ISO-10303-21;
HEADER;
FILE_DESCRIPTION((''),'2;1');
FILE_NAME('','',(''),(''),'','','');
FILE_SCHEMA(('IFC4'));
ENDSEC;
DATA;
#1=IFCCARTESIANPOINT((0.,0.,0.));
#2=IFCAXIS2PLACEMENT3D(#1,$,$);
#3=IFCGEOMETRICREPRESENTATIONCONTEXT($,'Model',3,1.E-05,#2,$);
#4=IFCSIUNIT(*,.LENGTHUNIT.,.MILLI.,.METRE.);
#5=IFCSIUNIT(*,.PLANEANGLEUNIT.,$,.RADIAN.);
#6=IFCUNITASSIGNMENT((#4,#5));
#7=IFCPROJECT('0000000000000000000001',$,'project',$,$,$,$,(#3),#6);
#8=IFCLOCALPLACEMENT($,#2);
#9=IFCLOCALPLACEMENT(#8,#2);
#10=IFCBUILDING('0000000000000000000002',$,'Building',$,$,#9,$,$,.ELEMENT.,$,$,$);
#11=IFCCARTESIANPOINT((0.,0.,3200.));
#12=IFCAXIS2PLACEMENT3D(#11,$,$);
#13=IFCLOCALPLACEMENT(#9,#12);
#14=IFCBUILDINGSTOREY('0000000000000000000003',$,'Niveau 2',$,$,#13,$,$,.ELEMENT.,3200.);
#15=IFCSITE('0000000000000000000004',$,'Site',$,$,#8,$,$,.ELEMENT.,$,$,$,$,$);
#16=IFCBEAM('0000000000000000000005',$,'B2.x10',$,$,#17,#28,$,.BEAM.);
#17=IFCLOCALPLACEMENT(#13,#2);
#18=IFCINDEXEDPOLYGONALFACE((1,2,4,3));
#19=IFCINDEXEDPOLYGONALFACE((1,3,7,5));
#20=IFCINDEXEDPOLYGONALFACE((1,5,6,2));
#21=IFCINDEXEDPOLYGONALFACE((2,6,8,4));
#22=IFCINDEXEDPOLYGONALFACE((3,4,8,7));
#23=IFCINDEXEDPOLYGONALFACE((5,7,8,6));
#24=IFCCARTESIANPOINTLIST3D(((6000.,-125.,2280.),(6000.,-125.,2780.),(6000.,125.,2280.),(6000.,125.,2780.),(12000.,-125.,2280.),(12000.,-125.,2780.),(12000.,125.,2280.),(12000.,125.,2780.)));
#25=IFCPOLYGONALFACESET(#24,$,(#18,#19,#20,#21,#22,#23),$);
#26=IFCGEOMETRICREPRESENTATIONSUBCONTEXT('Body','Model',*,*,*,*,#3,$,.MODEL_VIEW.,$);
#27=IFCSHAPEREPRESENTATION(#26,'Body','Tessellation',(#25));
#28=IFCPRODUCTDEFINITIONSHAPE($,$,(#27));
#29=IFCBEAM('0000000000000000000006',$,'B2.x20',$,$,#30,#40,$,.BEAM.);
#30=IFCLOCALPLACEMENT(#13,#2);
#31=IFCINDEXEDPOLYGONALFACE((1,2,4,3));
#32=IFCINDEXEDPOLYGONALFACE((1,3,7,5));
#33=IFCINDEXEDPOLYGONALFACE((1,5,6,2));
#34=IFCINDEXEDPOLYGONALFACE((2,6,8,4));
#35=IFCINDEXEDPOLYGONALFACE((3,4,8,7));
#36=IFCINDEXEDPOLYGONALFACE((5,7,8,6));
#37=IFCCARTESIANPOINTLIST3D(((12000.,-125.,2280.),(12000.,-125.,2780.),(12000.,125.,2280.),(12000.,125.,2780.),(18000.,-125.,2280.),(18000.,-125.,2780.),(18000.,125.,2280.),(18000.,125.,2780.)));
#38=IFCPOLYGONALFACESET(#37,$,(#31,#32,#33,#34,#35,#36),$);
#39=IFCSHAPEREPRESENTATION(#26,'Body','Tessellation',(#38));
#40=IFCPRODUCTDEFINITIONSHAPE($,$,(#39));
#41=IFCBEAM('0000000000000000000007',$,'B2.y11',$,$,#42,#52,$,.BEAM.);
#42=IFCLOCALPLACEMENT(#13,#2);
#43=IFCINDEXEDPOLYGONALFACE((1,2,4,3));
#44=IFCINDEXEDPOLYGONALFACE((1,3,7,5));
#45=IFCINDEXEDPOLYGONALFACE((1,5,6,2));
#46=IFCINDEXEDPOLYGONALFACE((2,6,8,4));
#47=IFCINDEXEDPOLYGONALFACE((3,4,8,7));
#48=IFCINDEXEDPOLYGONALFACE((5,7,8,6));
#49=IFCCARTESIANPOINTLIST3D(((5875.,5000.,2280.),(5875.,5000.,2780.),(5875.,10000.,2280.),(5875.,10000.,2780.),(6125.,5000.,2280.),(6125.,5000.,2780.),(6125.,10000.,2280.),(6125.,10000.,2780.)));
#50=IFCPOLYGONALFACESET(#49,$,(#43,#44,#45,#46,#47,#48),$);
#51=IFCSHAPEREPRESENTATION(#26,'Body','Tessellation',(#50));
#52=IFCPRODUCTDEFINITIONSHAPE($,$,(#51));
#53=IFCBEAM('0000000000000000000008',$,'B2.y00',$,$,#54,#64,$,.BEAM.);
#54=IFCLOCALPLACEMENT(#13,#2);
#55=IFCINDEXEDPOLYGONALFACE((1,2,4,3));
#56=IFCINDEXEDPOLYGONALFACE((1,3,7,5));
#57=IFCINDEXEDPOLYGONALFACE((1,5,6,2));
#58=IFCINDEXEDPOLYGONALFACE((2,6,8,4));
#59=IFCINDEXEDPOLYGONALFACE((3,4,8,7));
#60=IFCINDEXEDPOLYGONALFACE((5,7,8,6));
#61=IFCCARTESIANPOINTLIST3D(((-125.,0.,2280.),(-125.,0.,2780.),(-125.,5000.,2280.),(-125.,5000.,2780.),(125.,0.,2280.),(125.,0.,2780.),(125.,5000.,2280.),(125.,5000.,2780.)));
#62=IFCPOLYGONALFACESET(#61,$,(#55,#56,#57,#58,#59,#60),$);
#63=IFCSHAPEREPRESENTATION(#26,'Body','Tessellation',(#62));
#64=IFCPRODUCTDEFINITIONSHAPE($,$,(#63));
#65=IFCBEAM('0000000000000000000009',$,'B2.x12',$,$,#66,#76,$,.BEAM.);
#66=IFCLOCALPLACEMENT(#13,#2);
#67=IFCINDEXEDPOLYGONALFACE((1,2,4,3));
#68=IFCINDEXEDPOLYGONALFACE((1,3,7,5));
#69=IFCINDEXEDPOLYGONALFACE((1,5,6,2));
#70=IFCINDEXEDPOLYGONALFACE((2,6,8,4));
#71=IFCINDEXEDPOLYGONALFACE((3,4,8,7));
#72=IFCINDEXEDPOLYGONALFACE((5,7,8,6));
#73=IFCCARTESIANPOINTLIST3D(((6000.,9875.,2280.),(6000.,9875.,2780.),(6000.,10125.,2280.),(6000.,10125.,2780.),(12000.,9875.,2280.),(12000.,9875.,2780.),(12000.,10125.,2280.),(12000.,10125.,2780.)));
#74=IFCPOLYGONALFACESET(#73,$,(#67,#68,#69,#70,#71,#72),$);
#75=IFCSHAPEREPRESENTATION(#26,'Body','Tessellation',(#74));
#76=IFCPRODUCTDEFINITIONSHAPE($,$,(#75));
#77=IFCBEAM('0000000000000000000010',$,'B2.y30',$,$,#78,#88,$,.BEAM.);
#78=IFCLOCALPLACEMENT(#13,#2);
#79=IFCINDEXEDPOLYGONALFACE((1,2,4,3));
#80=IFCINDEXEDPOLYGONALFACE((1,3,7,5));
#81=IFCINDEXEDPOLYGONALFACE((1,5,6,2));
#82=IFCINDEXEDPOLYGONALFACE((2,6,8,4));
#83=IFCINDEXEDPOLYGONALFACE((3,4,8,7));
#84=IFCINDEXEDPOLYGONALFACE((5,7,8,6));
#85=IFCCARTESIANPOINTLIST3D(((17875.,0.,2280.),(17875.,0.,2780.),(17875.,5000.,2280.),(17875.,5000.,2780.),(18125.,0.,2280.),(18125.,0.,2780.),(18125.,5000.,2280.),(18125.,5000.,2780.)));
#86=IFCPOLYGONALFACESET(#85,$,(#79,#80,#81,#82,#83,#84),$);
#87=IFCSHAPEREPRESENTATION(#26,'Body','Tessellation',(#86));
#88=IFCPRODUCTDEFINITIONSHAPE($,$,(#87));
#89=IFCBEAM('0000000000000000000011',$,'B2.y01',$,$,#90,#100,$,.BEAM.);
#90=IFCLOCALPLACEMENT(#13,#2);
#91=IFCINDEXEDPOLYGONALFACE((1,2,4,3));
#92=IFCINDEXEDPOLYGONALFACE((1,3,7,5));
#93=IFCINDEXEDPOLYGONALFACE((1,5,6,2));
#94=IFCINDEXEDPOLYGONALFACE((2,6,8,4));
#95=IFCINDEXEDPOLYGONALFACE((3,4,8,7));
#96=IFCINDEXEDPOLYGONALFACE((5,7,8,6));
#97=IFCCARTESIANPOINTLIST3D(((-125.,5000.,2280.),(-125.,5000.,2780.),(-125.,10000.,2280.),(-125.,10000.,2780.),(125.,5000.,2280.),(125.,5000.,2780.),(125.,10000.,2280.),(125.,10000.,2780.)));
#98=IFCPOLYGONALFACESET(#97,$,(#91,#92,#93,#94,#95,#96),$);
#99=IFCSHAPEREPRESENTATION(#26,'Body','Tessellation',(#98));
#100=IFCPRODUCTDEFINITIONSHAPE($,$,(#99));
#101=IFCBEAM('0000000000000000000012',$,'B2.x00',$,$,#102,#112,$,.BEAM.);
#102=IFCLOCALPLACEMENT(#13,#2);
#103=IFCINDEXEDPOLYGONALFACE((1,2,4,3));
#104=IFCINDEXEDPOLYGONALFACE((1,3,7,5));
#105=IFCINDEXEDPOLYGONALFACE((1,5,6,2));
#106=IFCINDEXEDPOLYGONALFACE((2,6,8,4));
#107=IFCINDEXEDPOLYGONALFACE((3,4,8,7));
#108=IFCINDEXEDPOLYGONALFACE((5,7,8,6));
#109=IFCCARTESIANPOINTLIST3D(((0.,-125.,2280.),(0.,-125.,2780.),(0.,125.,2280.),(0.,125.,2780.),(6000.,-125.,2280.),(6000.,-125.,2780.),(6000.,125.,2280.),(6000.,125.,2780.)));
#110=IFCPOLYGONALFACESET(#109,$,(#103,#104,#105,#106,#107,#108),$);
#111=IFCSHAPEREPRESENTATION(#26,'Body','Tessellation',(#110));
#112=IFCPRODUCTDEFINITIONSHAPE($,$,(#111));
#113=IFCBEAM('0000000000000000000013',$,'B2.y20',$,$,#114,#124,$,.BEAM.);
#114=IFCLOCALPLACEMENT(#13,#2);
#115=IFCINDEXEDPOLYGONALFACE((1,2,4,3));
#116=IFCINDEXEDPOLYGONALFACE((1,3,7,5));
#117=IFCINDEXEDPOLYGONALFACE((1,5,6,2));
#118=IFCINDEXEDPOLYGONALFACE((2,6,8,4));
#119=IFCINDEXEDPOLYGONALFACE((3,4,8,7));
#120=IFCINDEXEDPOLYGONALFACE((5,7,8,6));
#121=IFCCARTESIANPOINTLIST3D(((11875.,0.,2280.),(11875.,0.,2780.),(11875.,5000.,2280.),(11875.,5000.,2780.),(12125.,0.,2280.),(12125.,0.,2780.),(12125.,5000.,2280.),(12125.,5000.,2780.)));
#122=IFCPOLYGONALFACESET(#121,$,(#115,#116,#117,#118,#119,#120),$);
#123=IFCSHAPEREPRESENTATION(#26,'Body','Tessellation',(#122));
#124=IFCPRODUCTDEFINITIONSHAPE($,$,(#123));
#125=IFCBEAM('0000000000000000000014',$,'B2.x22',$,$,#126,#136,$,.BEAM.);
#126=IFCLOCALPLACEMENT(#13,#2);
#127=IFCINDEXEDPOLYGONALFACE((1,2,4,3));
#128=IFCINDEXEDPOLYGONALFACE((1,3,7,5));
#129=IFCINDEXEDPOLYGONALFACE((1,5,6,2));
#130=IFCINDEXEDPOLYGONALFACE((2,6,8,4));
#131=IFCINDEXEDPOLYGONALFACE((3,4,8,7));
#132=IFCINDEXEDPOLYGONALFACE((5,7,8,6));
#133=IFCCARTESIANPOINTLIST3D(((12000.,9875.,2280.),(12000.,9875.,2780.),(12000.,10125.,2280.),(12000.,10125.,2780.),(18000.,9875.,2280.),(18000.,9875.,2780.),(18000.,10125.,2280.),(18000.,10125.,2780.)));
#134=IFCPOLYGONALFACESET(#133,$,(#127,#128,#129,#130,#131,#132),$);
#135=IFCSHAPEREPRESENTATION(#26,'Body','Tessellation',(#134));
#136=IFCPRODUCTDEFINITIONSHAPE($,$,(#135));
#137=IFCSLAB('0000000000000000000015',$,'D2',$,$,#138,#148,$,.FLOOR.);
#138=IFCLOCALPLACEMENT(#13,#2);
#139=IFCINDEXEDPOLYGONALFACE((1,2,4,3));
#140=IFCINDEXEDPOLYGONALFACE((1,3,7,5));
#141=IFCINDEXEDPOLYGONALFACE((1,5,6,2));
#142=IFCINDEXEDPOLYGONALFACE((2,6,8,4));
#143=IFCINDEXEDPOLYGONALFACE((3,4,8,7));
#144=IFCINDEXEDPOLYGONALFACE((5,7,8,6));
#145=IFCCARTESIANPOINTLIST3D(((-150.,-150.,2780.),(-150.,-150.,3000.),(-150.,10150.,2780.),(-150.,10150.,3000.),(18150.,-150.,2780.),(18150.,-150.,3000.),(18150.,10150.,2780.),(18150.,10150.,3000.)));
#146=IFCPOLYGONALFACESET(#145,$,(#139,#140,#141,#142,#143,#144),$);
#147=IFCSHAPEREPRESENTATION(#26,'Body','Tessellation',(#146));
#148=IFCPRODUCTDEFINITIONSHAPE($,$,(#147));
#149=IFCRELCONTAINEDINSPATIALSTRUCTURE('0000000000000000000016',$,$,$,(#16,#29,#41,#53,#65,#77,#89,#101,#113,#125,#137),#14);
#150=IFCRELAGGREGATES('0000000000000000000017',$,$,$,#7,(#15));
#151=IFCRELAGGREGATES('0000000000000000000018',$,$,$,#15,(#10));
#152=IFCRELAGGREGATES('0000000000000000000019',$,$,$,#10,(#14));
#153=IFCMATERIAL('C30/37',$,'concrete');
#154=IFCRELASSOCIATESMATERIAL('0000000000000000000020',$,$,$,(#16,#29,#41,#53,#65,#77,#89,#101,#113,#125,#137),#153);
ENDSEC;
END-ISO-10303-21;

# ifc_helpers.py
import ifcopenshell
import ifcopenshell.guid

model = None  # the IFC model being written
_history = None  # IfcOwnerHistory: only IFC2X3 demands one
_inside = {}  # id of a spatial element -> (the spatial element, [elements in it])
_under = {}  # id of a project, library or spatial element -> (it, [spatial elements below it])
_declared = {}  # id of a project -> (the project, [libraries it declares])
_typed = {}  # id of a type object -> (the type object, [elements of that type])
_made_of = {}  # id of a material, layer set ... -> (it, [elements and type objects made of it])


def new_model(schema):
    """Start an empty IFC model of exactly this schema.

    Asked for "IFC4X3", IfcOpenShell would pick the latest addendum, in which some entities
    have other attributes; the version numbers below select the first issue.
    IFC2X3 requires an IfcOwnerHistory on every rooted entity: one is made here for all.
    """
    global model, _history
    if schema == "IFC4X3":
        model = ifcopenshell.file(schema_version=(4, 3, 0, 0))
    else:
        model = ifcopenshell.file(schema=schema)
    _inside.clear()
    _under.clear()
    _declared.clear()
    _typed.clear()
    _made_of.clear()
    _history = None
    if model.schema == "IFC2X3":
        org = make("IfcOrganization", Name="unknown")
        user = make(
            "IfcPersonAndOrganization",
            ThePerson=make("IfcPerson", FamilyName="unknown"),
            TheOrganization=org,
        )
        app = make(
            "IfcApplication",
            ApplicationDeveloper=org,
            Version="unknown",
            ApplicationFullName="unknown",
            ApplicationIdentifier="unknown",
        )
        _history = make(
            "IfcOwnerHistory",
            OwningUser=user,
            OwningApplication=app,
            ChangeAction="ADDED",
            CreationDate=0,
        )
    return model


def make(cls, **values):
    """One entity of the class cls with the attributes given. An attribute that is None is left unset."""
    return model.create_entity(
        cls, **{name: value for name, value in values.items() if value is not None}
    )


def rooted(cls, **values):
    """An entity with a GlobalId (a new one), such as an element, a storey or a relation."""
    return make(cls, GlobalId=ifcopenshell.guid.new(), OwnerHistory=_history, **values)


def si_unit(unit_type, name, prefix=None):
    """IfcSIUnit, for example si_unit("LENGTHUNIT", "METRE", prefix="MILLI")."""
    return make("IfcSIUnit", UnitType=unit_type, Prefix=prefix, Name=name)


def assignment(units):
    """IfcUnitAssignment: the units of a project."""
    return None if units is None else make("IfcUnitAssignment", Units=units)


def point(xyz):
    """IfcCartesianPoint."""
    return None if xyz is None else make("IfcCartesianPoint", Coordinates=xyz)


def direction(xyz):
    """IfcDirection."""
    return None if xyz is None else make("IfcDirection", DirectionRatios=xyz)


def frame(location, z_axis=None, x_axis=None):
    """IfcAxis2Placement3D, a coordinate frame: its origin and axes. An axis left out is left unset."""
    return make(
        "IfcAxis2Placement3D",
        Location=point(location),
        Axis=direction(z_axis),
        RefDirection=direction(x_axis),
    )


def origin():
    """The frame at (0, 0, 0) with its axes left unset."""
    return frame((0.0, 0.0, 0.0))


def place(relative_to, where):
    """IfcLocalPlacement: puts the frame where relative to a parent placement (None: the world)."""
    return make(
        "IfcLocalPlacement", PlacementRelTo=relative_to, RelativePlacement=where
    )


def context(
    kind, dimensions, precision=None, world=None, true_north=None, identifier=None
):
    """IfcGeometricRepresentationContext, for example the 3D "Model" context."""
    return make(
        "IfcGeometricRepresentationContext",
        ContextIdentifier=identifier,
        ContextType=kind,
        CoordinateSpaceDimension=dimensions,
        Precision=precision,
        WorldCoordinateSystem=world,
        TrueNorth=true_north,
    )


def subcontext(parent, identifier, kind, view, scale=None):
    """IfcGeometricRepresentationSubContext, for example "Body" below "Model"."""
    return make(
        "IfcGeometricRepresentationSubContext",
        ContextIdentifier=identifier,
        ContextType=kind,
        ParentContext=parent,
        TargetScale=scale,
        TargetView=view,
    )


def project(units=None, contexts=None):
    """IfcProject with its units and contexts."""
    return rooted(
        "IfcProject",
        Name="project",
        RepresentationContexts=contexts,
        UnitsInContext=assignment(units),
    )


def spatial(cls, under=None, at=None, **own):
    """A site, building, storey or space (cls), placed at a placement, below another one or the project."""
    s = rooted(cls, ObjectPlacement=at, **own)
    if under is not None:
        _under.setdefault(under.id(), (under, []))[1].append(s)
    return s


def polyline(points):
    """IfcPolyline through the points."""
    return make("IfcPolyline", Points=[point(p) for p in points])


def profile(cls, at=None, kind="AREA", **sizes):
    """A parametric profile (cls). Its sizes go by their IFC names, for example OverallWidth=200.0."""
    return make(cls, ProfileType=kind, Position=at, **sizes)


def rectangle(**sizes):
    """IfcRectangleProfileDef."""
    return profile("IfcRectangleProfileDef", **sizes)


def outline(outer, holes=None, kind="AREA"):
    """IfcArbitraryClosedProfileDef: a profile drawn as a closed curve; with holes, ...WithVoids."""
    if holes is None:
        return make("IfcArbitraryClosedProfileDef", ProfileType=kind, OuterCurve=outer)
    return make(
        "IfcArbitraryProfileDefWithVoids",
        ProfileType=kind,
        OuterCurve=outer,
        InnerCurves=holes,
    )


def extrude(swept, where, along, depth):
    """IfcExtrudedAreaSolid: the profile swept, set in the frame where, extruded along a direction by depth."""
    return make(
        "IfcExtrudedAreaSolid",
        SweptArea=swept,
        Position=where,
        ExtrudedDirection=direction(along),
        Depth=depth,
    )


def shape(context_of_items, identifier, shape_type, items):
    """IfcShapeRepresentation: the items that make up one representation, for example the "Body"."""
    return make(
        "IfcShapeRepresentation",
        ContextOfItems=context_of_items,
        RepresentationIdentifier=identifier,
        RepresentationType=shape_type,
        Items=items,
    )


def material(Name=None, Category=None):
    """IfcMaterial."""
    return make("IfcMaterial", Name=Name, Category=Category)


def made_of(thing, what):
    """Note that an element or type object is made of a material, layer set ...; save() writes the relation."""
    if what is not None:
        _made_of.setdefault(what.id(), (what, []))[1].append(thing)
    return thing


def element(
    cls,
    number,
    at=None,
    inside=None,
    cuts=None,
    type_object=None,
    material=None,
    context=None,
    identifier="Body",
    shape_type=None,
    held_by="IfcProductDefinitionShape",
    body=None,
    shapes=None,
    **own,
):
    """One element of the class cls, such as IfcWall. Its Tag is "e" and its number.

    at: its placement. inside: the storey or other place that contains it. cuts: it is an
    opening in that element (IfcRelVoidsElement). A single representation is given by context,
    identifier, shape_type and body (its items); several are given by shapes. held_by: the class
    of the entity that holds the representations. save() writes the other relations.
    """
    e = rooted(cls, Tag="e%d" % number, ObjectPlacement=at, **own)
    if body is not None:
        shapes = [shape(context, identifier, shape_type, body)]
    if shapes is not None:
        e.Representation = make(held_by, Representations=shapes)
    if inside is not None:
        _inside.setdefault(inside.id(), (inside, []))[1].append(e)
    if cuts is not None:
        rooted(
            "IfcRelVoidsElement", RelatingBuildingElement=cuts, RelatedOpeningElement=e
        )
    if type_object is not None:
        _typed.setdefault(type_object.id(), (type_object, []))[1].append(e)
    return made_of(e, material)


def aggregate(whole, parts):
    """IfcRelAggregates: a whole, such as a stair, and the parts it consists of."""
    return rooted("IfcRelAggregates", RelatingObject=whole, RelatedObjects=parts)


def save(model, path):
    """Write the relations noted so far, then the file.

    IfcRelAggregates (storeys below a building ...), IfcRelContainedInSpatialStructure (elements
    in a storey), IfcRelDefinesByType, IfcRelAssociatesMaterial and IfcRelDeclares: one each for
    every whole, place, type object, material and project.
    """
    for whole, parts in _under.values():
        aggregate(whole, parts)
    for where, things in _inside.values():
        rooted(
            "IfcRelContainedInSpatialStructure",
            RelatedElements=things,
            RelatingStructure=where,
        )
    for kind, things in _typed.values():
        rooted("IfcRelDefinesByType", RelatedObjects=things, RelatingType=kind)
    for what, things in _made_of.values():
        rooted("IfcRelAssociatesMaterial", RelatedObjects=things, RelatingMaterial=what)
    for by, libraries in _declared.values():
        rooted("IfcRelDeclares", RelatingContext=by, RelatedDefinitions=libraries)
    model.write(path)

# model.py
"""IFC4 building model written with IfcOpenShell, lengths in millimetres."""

from ifc_helpers import new_model, si_unit, frame, origin, place, context, subcontext, project, spatial, polyline, rectangle, outline, extrude, material, element, save


model = new_model("IFC4")

# Units and contexts
model_context = context("Model", 3, precision=1e-05, world=origin())
body_context = subcontext(model_context, "Body", "Model", "MODEL_VIEW")
ifc_project = project(units=[si_unit("LENGTHUNIT", "METRE", prefix="MILLI"), si_unit("PLANEANGLEUNIT", "RADIAN")], contexts=[model_context])

# Site, building, storey
site_placement = place(None, origin())
site = spatial("IfcSite", under=ifc_project, at=site_placement, Name="Site", CompositionType="ELEMENT")
building_placement = place(site_placement, origin())
building = spatial("IfcBuilding", under=site, at=building_placement, Name="Building", CompositionType="ELEMENT")
storey_placement = place(building_placement, frame((0.0, 0.0, 3200.0)))
storey = spatial("IfcBuildingStorey", under=building, at=storey_placement, Name="Niveau 2", CompositionType="ELEMENT", Elevation=3200.0)

# Shared definitions
ifc_material = material(Name="C30/37", Category="concrete")

# Beams
for number, where, z_axis, x_axis, name in (
    (1, (6000.0, 0.0, 2530.0), (1.0, 0.0, 0.0), (0.0, 1.0, 0.0), "B2.x10"),
    (2, (12000.0, 0.0, 2530.0), (1.0, 0.0, 0.0), (0.0, 1.0, 0.0), "B2.x20"),
):
    element("IfcBeam", number, at=place(storey_placement, frame(where, z_axis=z_axis, x_axis=x_axis)), inside=storey, material=ifc_material, Name=name, PredefinedType="BEAM", context=body_context, shape_type="SweptSolid", body=[
        extrude(rectangle(XDim=250.0, YDim=500.0), origin(), (0.0, 0.0, 1.0), 6000.0),
    ])
for number, where, z_axis, x_axis, name in (
    (3, (6000.0, 5000.0, 2530.0), (0.0, 1.0, 0.0), (-1.0, 0.0, 0.0), "B2.y11"),
    (4, (0.0, 0.0, 2530.0), (0.0, 1.0, 0.0), (-1.0, 0.0, 0.0), "B2.y00"),
):
    element("IfcBeam", number, at=place(storey_placement, frame(where, z_axis=z_axis, x_axis=x_axis)), inside=storey, material=ifc_material, Name=name, PredefinedType="BEAM", context=body_context, shape_type="SweptSolid", body=[
        extrude(rectangle(XDim=250.0, YDim=500.0), origin(), (0.0, 0.0, 1.0), 5000.0),
    ])
beam_1_placement = place(storey_placement, frame((6000.0, 10000.0, 2530.0), z_axis=(1.0, 0.0, 0.0), x_axis=(0.0, 1.0, 0.0)))
element("IfcBeam", 5, at=beam_1_placement, inside=storey, material=ifc_material, Name="B2.x12", PredefinedType="BEAM", context=body_context, shape_type="SweptSolid", body=[
    extrude(rectangle(XDim=250.0, YDim=500.0), origin(), (0.0, 0.0, 1.0), 6000.0),
])
for number, where, z_axis, x_axis, name in (
    (6, (18000.0, 0.0, 2530.0), (0.0, 1.0, 0.0), (-1.0, 0.0, 0.0), "B2.y30"),
    (7, (0.0, 5000.0, 2530.0), (0.0, 1.0, 0.0), (-1.0, 0.0, 0.0), "B2.y01"),
):
    element("IfcBeam", number, at=place(storey_placement, frame(where, z_axis=z_axis, x_axis=x_axis)), inside=storey, material=ifc_material, Name=name, PredefinedType="BEAM", context=body_context, shape_type="SweptSolid", body=[
        extrude(rectangle(XDim=250.0, YDim=500.0), origin(), (0.0, 0.0, 1.0), 5000.0),
    ])
beam_2_placement = place(storey_placement, frame((0.0, 0.0, 2530.0), z_axis=(1.0, 0.0, 0.0), x_axis=(0.0, 1.0, 0.0)))
element("IfcBeam", 8, at=beam_2_placement, inside=storey, material=ifc_material, Name="B2.x00", PredefinedType="BEAM", context=body_context, shape_type="SweptSolid", body=[
    extrude(rectangle(XDim=250.0, YDim=500.0), origin(), (0.0, 0.0, 1.0), 6000.0),
])
beam_3_placement = place(storey_placement, frame((12000.0, 0.0, 2530.0), z_axis=(0.0, 1.0, 0.0), x_axis=(-1.0, 0.0, 0.0)))
element("IfcBeam", 9, at=beam_3_placement, inside=storey, material=ifc_material, Name="B2.y20", PredefinedType="BEAM", context=body_context, shape_type="SweptSolid", body=[
    extrude(rectangle(XDim=250.0, YDim=500.0), origin(), (0.0, 0.0, 1.0), 5000.0),
])
beam_4_placement = place(storey_placement, frame((12000.0, 10000.0, 2530.0), z_axis=(1.0, 0.0, 0.0), x_axis=(0.0, 1.0, 0.0)))
element("IfcBeam", 10, at=beam_4_placement, inside=storey, material=ifc_material, Name="B2.x22", PredefinedType="BEAM", context=body_context, shape_type="SweptSolid", body=[
    extrude(rectangle(XDim=250.0, YDim=500.0), origin(), (0.0, 0.0, 1.0), 6000.0),
])

# Slab
slab_placement = place(storey_placement, frame((0.0, 0.0, 2780.0), z_axis=(0.0, 0.0, 1.0), x_axis=(1.0, 0.0, 0.0)))
element("IfcSlab", 11, at=slab_placement, inside=storey, material=ifc_material, Name="D2", PredefinedType="FLOOR", context=body_context, shape_type="SweptSolid", body=[
    extrude(outline(polyline([(-150.0, -150.0), (18150.0, -150.0), (18150.0, 10150.0), (-150.0, 10150.0), (-150.0, -150.0)])), origin(), (0.0, 0.0, 1.0), 220.0),
])

save(model, "model.ifc")
